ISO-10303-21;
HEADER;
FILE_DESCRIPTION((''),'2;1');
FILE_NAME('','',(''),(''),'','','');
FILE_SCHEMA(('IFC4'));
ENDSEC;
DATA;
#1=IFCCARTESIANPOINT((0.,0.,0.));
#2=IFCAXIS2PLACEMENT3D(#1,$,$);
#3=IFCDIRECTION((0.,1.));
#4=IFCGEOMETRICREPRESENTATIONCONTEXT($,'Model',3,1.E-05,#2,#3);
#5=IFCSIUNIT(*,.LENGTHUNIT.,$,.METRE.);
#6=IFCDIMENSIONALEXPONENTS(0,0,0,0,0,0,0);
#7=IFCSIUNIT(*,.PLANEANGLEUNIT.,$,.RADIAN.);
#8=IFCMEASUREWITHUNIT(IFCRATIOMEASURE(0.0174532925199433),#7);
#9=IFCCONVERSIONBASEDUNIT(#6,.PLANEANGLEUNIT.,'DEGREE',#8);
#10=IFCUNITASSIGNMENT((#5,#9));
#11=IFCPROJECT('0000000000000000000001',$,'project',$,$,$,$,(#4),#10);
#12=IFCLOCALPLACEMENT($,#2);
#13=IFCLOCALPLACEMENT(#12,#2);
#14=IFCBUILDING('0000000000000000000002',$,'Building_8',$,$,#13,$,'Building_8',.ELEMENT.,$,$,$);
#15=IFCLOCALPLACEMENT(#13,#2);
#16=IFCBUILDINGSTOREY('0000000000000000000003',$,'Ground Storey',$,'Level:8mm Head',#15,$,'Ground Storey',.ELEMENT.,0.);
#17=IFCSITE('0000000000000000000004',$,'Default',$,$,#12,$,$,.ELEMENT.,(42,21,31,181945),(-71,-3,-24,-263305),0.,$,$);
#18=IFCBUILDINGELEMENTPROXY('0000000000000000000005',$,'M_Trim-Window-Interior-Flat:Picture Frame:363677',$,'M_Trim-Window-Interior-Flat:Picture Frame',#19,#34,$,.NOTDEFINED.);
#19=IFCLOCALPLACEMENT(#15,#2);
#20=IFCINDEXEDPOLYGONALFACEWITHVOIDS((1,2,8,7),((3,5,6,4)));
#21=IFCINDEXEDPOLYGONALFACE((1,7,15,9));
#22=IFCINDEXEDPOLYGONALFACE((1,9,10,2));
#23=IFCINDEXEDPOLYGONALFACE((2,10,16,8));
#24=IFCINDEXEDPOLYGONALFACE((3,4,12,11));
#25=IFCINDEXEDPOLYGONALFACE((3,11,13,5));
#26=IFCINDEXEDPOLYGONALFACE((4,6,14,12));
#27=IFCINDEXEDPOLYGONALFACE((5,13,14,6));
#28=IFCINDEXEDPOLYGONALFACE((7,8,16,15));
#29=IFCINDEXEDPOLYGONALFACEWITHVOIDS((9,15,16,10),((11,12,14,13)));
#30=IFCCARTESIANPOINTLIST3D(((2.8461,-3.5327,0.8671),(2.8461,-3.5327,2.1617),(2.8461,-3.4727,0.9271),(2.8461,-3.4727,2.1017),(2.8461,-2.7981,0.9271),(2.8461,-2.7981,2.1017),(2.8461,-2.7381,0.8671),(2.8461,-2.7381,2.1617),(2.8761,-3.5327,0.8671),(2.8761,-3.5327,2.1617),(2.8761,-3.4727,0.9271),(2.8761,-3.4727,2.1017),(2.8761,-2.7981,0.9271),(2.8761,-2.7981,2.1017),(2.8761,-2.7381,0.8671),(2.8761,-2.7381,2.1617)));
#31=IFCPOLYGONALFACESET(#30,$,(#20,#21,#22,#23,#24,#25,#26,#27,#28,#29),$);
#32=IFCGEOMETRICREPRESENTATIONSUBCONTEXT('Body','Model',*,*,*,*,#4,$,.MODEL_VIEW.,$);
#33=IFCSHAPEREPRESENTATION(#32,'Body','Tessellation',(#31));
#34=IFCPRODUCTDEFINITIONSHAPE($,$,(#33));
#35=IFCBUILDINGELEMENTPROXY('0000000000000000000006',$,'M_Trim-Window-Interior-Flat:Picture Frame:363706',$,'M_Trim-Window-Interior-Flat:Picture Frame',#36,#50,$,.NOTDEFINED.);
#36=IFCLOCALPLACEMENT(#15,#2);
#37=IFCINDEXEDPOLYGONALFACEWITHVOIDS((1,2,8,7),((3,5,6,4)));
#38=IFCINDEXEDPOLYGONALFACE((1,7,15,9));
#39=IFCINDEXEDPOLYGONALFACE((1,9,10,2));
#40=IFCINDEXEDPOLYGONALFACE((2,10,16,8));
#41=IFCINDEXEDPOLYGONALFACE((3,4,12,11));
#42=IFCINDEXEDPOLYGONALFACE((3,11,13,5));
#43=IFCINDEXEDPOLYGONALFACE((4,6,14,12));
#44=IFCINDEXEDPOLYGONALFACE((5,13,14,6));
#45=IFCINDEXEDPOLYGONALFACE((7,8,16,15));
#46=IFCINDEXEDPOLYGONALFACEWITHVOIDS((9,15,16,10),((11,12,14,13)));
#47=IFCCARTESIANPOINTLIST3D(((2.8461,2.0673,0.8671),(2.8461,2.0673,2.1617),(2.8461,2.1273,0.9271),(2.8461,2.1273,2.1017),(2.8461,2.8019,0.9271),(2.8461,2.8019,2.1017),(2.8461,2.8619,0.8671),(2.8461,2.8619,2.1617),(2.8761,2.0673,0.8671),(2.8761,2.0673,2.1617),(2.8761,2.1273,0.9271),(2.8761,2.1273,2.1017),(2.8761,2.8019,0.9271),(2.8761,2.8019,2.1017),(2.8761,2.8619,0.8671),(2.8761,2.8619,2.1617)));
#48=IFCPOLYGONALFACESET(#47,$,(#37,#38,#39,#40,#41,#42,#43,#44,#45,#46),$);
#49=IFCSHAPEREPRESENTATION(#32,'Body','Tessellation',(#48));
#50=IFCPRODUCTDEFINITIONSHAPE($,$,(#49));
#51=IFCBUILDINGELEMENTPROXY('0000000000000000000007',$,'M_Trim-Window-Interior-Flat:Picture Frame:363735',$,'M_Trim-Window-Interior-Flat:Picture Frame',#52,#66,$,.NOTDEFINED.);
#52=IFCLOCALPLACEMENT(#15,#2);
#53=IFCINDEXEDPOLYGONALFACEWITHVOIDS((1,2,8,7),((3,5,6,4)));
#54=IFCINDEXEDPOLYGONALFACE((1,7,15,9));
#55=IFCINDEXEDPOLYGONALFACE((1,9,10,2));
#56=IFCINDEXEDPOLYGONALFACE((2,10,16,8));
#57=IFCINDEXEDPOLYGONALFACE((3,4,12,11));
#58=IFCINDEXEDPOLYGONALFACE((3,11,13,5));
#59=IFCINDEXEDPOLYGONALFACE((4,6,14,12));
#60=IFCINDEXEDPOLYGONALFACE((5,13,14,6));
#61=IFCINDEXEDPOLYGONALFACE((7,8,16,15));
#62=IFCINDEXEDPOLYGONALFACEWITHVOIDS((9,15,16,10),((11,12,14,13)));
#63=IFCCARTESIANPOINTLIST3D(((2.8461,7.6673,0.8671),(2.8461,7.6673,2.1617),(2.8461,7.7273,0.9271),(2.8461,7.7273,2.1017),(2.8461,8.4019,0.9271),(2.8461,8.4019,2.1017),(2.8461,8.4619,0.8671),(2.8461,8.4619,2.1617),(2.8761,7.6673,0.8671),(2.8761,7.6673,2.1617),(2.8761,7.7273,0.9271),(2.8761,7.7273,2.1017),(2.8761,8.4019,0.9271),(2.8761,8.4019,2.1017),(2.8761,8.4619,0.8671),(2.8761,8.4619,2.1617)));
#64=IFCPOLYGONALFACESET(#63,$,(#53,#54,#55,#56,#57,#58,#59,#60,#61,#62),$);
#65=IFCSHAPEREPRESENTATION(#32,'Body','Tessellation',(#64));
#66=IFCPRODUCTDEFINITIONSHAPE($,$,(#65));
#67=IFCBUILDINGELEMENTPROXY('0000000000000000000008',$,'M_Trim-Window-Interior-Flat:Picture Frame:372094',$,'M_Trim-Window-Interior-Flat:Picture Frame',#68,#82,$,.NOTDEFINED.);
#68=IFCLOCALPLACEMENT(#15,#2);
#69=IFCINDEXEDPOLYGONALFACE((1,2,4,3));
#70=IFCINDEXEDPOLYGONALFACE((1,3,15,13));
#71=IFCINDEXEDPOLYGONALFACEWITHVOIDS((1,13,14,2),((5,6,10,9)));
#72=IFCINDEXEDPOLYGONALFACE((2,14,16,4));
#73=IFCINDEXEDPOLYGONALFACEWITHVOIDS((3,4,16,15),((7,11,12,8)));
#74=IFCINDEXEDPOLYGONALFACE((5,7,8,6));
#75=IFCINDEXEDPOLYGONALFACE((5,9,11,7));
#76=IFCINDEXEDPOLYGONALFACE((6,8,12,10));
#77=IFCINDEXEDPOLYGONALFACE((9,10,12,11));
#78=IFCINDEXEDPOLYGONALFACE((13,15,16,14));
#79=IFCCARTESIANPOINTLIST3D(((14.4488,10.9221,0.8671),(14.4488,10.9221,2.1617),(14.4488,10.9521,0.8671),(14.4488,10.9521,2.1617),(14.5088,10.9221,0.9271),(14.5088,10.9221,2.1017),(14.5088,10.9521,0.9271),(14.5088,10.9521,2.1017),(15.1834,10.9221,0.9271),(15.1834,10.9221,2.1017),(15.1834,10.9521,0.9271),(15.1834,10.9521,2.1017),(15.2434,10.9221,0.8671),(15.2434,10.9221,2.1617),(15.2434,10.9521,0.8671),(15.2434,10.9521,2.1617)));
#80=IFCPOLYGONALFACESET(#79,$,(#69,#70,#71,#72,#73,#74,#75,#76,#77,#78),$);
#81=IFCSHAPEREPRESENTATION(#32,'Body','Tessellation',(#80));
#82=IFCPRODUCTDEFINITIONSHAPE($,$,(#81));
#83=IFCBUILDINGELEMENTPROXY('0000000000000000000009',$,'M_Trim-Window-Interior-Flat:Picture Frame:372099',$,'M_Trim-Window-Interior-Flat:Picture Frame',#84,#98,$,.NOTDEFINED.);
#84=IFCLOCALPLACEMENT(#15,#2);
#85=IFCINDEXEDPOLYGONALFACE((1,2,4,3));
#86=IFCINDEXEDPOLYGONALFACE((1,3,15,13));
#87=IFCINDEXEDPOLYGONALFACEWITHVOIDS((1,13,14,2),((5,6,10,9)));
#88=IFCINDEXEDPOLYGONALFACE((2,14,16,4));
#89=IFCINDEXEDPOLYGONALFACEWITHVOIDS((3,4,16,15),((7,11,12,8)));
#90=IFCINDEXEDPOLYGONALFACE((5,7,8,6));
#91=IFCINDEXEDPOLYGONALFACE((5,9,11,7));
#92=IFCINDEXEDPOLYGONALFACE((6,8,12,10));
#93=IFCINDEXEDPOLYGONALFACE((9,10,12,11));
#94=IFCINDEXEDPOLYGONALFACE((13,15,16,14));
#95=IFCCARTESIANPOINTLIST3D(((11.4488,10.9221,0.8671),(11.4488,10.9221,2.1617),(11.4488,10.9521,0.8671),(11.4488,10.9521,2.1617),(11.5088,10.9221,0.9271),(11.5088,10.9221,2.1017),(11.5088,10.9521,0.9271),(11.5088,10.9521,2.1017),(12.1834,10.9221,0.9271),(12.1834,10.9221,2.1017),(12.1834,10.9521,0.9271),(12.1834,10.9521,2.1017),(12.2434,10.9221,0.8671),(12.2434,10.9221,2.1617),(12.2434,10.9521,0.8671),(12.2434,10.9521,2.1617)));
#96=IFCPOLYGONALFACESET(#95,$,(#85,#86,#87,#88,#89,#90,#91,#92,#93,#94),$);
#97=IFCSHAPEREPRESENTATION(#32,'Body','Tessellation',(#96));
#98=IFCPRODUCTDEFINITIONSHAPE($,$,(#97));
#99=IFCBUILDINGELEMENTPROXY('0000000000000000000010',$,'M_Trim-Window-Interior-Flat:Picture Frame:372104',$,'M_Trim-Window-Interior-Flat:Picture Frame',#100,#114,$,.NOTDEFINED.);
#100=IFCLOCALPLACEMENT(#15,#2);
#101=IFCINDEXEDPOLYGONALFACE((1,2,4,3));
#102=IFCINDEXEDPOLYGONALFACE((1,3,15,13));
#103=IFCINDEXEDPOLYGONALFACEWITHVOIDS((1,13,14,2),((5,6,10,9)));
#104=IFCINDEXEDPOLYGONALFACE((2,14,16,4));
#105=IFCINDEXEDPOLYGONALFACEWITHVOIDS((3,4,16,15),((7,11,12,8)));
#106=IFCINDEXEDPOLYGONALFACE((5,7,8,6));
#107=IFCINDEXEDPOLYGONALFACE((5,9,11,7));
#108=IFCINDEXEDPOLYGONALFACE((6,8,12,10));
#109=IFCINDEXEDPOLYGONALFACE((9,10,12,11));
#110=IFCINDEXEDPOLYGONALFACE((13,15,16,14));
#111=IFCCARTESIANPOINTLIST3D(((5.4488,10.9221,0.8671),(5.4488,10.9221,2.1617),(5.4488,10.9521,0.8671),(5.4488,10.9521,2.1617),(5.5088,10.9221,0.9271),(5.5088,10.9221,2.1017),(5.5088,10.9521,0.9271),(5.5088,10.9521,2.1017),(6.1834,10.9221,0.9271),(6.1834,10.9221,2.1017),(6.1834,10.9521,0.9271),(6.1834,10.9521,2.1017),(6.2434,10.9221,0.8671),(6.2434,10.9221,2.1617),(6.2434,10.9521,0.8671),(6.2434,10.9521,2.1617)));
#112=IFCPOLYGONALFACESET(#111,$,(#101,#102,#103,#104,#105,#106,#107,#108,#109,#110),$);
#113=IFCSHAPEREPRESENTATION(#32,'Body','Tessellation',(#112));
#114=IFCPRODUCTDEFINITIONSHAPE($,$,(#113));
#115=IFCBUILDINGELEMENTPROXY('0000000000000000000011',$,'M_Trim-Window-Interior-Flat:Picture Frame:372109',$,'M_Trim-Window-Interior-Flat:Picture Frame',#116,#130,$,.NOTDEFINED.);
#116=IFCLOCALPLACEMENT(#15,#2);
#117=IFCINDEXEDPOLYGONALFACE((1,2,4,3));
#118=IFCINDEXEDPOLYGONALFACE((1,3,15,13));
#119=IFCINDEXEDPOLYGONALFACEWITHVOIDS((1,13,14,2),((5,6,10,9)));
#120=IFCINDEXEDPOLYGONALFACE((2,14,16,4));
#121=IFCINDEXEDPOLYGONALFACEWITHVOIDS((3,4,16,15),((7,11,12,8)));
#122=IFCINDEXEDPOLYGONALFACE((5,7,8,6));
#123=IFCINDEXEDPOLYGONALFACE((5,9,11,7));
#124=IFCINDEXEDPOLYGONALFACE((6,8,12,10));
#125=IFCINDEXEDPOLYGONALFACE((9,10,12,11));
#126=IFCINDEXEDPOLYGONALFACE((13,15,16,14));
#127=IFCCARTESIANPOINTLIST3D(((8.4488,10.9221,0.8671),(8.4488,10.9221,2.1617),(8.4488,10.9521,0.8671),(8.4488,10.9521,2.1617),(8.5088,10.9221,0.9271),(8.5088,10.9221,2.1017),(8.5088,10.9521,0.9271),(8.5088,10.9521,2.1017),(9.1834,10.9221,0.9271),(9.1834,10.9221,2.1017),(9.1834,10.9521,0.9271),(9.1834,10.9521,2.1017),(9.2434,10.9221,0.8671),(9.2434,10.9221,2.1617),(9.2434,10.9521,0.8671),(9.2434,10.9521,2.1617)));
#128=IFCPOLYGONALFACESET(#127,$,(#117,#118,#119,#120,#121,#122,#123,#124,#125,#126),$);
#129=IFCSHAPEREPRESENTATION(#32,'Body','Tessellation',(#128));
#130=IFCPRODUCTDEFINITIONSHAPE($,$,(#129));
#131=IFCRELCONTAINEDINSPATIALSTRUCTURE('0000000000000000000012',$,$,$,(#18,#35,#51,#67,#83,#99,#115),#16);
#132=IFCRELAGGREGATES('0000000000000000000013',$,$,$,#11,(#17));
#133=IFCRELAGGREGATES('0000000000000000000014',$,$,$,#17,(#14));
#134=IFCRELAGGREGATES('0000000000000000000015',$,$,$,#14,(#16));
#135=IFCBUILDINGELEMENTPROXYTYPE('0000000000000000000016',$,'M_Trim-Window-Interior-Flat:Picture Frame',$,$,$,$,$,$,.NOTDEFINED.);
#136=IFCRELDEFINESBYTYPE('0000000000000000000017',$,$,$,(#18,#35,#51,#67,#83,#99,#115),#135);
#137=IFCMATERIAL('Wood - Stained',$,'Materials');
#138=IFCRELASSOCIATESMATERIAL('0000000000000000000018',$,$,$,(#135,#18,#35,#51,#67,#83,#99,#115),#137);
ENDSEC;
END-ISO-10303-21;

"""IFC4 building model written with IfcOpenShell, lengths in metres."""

from ifc_helpers import new_model, entity, si_unit, converted_unit, direction, frame, origin, place, context, subcontext, project, spatial, indexed_curve, outline, extrude, source, transform, mapped, material, type_object, type_shapes, element, save


model = new_model("IFC4")

# Units and contexts
model_context = context("Model", 3, precision=1e-05, world=origin(), true_north=direction((0.0, 1.0)))
body_context = subcontext(model_context, "Body", "Model", "MODEL_VIEW")
ifc_project = project(units=[si_unit("LENGTHUNIT", "METRE"), converted_unit("PLANEANGLEUNIT", "DEGREE", entity("IfcRatioMeasure", 0.0174532925199433), si_unit("PLANEANGLEUNIT", "RADIAN"), dimensions=[0, 0, 0, 0, 0, 0, 0])], contexts=[model_context])

# Site, building, storey
site_placement = place(None, origin())
site = spatial("IfcSite", under=ifc_project, at=site_placement, Name="Default", CompositionType="ELEMENT", RefLatitude=(42, 21, 31, 181945), RefLongitude=(-71, -3, -24, -263305), RefElevation=0.0)
building_placement = place(site_placement, origin())
building = spatial("IfcBuilding", under=site, at=building_placement, Name="Building_8", LongName="Building_8", CompositionType="ELEMENT")
storey_placement = place(building_placement, origin())
storey = spatial("IfcBuildingStorey", under=building, at=storey_placement, Name="Ground Storey", ObjectType="Level:8mm Head", LongName="Ground Storey", CompositionType="ELEMENT", Elevation=0.0)

# Shared definitions
ifc_material_1 = material(Name="Wood - Stained", Category="Materials")

# Building element proxies
building_element_proxy_type_1 = type_object("IfcBuildingElementProxyType", Name="M_Trim-Window-Interior-Flat:Picture Frame", PredefinedType="NOTDEFINED", material=ifc_material_1)
shared_shape_1 = source(origin(), body_context, "Body", "SweptSolid", [
    extrude(outline(indexed_curve([(-0.3973, -0.6473), (0.3973, -0.6473), (0.3973, 0.6473), (-0.3973, 0.6473), (-0.3973, -0.6473)], self_intersect=False), holes=[indexed_curve([(-0.3373, -0.5873), (-0.3373, 0.5873), (0.3373, 0.5873), (0.3373, -0.5873), (-0.3373, -0.5873)], self_intersect=False)]), frame((0.0, -0.6, 0.0), z_axis=(0.0, 0.0, 1.0), x_axis=(-1.0, 0.0, 0.0)), (0.0, 0.0, 1.0), 0.03),
])
type_shapes(building_element_proxy_type_1, [shared_shape_1])
for number, where, z_axis, x_axis, name in (
    (1, (2.8461, -3.1354, 2.1144), (1.0, 0.0, 0.0), (0.0, 1.0, 0.0), "M_Trim-Window-Interior-Flat:Picture Frame:363677"),
    (2, (2.8461, 2.4646, 2.1144), (1.0, 0.0, 0.0), (0.0, 1.0, 0.0), "M_Trim-Window-Interior-Flat:Picture Frame:363706"),
    (3, (2.8461, 8.0646, 2.1144), (1.0, 0.0, 0.0), (0.0, 1.0, 0.0), "M_Trim-Window-Interior-Flat:Picture Frame:363735"),
    (4, (14.8461, 10.9521, 2.1144), (0.0, -1.0, 0.0), (1.0, 0.0, 0.0), "M_Trim-Window-Interior-Flat:Picture Frame:372094"),
    (5, (11.8461, 10.9521, 2.1144), (0.0, -1.0, 0.0), (1.0, 0.0, 0.0), "M_Trim-Window-Interior-Flat:Picture Frame:372099"),
    (6, (5.8461, 10.9521, 2.1144), (0.0, -1.0, 0.0), (1.0, 0.0, 0.0), "M_Trim-Window-Interior-Flat:Picture Frame:372104"),
    (7, (8.8461, 10.9521, 2.1144), (0.0, -1.0, 0.0), (1.0, 0.0, 0.0), "M_Trim-Window-Interior-Flat:Picture Frame:372109"),
):
    element("IfcBuildingElementProxy", number, at=place(storey_placement, frame(where, z_axis=z_axis, x_axis=x_axis)), inside=storey, type_object=building_element_proxy_type_1, material=ifc_material_1, Name=name, ObjectType="M_Trim-Window-Interior-Flat:Picture Frame", PredefinedType="NOTDEFINED", context=body_context, shape_type="MappedRepresentation", body=[
        mapped(shared_shape_1, transform((0.0, 0.0, 0.0), scale=1.0)),
    ])

save(model, "model.ifc")
